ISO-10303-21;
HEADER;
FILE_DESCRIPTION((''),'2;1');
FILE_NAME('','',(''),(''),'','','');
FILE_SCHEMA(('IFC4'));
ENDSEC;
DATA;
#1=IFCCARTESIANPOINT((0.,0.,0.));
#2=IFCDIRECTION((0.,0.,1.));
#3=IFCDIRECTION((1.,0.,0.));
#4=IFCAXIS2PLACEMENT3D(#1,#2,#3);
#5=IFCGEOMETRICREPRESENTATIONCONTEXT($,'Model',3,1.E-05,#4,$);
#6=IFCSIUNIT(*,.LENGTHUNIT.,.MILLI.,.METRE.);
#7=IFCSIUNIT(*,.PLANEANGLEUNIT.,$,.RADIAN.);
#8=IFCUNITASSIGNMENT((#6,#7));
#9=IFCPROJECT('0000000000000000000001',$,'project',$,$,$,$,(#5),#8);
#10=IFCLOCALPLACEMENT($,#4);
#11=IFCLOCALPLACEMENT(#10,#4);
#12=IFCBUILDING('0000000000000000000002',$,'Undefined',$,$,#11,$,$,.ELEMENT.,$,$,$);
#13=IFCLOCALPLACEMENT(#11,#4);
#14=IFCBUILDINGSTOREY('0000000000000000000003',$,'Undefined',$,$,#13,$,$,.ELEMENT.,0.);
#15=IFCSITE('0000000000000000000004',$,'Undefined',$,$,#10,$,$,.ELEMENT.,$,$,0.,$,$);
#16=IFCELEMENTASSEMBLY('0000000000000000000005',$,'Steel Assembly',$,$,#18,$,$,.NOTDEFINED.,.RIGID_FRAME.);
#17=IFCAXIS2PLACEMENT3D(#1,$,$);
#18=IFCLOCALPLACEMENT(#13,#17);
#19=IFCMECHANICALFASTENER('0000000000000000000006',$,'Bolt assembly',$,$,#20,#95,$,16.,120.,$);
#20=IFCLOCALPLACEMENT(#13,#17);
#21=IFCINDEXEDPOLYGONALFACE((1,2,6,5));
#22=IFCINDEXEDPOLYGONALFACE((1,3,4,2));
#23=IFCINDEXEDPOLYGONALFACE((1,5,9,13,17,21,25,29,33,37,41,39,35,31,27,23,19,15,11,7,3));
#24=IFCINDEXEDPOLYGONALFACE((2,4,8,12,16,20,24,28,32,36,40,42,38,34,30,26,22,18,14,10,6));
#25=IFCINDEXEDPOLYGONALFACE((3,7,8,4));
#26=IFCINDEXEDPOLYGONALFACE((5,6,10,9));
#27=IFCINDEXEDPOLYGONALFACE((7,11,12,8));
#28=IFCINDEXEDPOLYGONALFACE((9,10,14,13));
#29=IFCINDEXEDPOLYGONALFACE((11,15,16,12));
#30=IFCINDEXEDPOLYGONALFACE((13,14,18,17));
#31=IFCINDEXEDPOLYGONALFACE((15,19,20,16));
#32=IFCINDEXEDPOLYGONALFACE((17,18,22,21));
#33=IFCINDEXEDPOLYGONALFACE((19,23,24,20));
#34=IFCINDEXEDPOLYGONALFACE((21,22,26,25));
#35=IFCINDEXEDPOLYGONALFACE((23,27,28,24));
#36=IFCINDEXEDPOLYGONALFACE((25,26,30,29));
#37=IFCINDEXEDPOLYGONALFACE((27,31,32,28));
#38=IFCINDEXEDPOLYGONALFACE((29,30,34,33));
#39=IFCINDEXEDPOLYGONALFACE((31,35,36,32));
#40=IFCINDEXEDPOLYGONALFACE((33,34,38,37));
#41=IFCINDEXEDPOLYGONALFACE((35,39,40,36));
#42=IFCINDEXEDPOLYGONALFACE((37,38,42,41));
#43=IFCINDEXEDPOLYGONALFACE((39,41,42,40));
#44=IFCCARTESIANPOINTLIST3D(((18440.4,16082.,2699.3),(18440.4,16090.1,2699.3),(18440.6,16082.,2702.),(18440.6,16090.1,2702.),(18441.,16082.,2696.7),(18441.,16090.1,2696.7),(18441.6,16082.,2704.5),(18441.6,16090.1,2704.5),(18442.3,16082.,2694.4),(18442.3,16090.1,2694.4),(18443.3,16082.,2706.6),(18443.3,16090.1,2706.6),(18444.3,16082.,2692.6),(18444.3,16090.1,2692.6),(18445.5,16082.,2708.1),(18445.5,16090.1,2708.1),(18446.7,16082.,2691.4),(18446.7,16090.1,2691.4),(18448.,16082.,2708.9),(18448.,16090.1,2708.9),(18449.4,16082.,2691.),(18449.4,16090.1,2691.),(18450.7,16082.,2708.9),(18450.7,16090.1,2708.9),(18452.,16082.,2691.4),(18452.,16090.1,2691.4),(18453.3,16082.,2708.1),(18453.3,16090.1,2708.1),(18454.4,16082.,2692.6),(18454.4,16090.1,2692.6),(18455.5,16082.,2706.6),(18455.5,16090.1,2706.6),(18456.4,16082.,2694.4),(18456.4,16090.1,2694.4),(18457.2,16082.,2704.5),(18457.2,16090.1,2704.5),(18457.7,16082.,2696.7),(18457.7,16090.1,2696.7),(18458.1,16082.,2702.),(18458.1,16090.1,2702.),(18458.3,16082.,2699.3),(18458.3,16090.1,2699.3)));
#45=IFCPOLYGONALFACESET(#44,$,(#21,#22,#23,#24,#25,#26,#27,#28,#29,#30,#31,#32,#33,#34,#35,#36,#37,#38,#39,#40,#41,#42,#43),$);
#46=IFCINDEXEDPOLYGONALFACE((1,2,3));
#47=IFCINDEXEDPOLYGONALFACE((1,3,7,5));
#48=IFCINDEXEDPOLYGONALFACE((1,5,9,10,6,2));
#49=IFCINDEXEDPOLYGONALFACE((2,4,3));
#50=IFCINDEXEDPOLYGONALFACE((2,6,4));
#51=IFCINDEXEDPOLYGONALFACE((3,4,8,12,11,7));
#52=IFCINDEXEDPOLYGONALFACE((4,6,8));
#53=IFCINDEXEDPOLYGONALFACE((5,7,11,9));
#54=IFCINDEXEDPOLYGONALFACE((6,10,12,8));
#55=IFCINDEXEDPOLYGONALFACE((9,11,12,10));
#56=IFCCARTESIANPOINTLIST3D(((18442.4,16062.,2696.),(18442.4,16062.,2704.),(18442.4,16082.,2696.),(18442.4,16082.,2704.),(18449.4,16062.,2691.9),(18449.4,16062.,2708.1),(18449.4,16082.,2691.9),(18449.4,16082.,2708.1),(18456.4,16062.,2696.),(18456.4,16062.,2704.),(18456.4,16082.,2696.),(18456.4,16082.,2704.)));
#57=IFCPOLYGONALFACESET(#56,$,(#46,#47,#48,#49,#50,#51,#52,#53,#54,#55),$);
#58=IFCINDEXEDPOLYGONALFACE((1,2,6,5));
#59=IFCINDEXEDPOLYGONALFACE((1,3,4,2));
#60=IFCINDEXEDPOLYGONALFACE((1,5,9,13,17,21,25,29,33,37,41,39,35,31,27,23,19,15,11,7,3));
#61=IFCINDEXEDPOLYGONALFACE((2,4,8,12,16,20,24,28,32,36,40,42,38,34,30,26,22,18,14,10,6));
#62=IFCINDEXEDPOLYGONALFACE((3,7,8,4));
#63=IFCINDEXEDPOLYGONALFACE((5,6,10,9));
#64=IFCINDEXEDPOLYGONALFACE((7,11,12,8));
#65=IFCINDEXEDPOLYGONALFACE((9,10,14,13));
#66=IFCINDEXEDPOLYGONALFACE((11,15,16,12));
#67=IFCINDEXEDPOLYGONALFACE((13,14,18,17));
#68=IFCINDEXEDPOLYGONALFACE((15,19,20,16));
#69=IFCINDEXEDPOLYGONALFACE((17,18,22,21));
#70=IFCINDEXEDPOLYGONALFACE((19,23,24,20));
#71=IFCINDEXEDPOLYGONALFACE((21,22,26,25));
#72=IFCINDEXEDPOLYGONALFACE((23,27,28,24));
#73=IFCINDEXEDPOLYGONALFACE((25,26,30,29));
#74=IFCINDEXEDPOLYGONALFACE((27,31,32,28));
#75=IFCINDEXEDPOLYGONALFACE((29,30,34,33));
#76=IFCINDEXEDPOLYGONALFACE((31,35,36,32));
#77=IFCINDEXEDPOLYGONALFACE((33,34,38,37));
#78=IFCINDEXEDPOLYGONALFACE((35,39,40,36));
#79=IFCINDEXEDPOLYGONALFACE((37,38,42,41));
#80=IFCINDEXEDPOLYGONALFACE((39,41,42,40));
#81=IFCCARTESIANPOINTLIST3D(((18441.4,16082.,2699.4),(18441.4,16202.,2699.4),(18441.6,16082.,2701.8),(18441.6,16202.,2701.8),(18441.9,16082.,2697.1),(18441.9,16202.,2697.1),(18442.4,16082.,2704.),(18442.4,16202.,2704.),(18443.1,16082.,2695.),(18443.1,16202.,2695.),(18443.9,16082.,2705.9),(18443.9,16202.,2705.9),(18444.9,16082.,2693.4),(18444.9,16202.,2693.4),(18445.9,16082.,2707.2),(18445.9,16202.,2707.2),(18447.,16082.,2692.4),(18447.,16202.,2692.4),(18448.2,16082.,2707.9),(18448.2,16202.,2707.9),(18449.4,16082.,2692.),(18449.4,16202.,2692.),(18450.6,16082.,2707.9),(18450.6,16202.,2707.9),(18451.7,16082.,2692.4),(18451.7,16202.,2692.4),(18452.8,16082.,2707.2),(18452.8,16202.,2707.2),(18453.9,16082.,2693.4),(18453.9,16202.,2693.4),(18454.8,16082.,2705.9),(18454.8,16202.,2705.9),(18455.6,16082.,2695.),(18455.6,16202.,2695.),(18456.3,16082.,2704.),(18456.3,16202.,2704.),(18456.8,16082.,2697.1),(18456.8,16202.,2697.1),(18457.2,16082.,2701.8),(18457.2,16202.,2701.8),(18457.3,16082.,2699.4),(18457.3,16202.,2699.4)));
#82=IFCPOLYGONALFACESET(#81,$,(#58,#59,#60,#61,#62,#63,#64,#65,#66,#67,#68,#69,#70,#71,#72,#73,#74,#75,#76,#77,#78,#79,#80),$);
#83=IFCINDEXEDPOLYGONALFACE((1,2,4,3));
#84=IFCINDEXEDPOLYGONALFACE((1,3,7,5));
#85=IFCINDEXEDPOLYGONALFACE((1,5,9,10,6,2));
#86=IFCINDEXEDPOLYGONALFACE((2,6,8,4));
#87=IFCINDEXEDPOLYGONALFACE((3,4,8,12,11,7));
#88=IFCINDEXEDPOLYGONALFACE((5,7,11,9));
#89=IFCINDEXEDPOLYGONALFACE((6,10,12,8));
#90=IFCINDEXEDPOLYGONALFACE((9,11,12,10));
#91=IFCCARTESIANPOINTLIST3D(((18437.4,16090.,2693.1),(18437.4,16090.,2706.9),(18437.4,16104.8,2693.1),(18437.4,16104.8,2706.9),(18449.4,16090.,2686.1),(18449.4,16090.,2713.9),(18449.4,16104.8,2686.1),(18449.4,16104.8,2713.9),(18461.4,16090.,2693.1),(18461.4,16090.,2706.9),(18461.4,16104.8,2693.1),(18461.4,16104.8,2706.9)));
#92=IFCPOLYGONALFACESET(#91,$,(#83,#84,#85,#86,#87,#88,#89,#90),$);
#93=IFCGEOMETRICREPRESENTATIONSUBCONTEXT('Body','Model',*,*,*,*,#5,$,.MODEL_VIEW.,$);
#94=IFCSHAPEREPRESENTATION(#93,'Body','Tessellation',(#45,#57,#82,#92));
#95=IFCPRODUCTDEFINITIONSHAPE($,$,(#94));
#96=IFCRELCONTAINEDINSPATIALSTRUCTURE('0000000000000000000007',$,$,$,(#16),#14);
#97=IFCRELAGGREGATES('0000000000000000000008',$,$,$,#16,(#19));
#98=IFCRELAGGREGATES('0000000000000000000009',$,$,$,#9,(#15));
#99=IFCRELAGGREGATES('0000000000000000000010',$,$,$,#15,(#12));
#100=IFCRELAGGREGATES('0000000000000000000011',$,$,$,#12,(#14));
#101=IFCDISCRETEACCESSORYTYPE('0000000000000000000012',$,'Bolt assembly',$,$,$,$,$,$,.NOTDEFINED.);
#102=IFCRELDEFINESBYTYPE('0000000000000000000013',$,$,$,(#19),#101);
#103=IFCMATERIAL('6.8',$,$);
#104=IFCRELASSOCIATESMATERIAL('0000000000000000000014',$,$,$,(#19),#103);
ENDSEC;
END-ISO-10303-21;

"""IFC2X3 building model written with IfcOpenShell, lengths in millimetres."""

from ifc_helpers import new_model, si_unit, frame, origin_with_axes, origin_2d_with_axis, place, context, subcontext, project, spatial, polyline, circle, outline, extrude, source, transform, mapped, material, type_object, element, aggregate, save


model = new_model("IFC2X3")

# Units and contexts
model_context = context("Model", 3, precision=1e-05, world=origin_with_axes())
body_context = subcontext(model_context, "Body", "Model", "MODEL_VIEW")
ifc_project = project(units=[si_unit("LENGTHUNIT", "METRE", prefix="MILLI"), si_unit("PLANEANGLEUNIT", "RADIAN")], contexts=[model_context])

# Site, building, storey
site_placement = place(None, origin_with_axes())
site = spatial("IfcSite", under=ifc_project, at=site_placement, Name="Undefined", CompositionType="ELEMENT", RefElevation=0.0)
building_placement = place(site_placement, origin_with_axes())
building = spatial("IfcBuilding", under=site, at=building_placement, Name="Undefined", CompositionType="ELEMENT")
storey_placement = place(building_placement, origin_with_axes())
storey = spatial("IfcBuildingStorey", under=building, at=storey_placement, Name="Undefined", CompositionType="ELEMENT", Elevation=0.0)

# Element assembly
assembly_1_placement = place(storey_placement, origin_with_axes())
assembly_1 = element("IfcElementAssembly", 1, at=assembly_1_placement, inside=storey, Name="Steel Assembly", AssemblyPlace="NOTDEFINED", PredefinedType="RIGID_FRAME")

# Shared definitions
ifc_material_1 = material(Name="6.8")
discrete_accessory_type_1 = type_object("IfcDiscreteAccessoryType", Name="Bolt assembly")
shared_shape_1 = source(origin_with_axes(), body_context, "Body", "SweptSolid", [
    extrude(circle(Radius=9.0, at=origin_2d_with_axis()), frame((0.0, -8.0, 0.0), z_axis=(0.0, 1.0, 0.0), x_axis=(1.0, 0.0, 0.0)), (0.0, 0.0, 1.0), 8.1),
    extrude(outline(polyline([(8.1, 0.0), (4.0, 7.0), (-4.0, 7.0), (-8.1, 0.0), (-4.0, -7.0), (4.0, -7.0), (8.1, 0.0)])), frame((0.0, -28.0, 0.0), z_axis=(0.0, 1.0, 0.0), x_axis=(1.0, 0.0, 0.0)), (0.0, 0.0, 1.0), 20.0),
    extrude(circle(Radius=8.0, at=origin_2d_with_axis()), frame((0.0, -8.0, 0.0), z_axis=(0.0, 1.0, 0.0), x_axis=(1.0, 0.0, 0.0)), (0.0, 0.0, 1.0), 120.0),
    extrude(outline(polyline([(13.9, 0.0), (6.9, 12.0), (-6.9, 12.0), (-13.9, 0.0), (-6.9, -12.0), (6.9, -12.0), (13.9, 0.0)])), frame((0.0, 0.0, 0.0), z_axis=(0.0, 1.0, 0.0), x_axis=(1.0, 0.0, 0.0)), (0.0, 0.0, 1.0), 14.8),
])

# Mechanical fastener
mechanical_fastener_1_placement = place(assembly_1_placement, frame((18449.4, 16090.0, 2700.0), z_axis=(1.0, 0.0, 0.0), x_axis=(0.0, 0.0, -1.0)))
mechanical_fastener_1 = element("IfcMechanicalFastener", 2, at=mechanical_fastener_1_placement, type_object=discrete_accessory_type_1, material=ifc_material_1, Name="Bolt assembly", NominalDiameter=16.0, NominalLength=120.0, context=body_context, shape_type="MappedRepresentation", body=[
    mapped(shared_shape_1, transform((0.0, 0.0, 0.0))),
])

aggregate(assembly_1, [mechanical_fastener_1])

save(model, "model.ifc")
